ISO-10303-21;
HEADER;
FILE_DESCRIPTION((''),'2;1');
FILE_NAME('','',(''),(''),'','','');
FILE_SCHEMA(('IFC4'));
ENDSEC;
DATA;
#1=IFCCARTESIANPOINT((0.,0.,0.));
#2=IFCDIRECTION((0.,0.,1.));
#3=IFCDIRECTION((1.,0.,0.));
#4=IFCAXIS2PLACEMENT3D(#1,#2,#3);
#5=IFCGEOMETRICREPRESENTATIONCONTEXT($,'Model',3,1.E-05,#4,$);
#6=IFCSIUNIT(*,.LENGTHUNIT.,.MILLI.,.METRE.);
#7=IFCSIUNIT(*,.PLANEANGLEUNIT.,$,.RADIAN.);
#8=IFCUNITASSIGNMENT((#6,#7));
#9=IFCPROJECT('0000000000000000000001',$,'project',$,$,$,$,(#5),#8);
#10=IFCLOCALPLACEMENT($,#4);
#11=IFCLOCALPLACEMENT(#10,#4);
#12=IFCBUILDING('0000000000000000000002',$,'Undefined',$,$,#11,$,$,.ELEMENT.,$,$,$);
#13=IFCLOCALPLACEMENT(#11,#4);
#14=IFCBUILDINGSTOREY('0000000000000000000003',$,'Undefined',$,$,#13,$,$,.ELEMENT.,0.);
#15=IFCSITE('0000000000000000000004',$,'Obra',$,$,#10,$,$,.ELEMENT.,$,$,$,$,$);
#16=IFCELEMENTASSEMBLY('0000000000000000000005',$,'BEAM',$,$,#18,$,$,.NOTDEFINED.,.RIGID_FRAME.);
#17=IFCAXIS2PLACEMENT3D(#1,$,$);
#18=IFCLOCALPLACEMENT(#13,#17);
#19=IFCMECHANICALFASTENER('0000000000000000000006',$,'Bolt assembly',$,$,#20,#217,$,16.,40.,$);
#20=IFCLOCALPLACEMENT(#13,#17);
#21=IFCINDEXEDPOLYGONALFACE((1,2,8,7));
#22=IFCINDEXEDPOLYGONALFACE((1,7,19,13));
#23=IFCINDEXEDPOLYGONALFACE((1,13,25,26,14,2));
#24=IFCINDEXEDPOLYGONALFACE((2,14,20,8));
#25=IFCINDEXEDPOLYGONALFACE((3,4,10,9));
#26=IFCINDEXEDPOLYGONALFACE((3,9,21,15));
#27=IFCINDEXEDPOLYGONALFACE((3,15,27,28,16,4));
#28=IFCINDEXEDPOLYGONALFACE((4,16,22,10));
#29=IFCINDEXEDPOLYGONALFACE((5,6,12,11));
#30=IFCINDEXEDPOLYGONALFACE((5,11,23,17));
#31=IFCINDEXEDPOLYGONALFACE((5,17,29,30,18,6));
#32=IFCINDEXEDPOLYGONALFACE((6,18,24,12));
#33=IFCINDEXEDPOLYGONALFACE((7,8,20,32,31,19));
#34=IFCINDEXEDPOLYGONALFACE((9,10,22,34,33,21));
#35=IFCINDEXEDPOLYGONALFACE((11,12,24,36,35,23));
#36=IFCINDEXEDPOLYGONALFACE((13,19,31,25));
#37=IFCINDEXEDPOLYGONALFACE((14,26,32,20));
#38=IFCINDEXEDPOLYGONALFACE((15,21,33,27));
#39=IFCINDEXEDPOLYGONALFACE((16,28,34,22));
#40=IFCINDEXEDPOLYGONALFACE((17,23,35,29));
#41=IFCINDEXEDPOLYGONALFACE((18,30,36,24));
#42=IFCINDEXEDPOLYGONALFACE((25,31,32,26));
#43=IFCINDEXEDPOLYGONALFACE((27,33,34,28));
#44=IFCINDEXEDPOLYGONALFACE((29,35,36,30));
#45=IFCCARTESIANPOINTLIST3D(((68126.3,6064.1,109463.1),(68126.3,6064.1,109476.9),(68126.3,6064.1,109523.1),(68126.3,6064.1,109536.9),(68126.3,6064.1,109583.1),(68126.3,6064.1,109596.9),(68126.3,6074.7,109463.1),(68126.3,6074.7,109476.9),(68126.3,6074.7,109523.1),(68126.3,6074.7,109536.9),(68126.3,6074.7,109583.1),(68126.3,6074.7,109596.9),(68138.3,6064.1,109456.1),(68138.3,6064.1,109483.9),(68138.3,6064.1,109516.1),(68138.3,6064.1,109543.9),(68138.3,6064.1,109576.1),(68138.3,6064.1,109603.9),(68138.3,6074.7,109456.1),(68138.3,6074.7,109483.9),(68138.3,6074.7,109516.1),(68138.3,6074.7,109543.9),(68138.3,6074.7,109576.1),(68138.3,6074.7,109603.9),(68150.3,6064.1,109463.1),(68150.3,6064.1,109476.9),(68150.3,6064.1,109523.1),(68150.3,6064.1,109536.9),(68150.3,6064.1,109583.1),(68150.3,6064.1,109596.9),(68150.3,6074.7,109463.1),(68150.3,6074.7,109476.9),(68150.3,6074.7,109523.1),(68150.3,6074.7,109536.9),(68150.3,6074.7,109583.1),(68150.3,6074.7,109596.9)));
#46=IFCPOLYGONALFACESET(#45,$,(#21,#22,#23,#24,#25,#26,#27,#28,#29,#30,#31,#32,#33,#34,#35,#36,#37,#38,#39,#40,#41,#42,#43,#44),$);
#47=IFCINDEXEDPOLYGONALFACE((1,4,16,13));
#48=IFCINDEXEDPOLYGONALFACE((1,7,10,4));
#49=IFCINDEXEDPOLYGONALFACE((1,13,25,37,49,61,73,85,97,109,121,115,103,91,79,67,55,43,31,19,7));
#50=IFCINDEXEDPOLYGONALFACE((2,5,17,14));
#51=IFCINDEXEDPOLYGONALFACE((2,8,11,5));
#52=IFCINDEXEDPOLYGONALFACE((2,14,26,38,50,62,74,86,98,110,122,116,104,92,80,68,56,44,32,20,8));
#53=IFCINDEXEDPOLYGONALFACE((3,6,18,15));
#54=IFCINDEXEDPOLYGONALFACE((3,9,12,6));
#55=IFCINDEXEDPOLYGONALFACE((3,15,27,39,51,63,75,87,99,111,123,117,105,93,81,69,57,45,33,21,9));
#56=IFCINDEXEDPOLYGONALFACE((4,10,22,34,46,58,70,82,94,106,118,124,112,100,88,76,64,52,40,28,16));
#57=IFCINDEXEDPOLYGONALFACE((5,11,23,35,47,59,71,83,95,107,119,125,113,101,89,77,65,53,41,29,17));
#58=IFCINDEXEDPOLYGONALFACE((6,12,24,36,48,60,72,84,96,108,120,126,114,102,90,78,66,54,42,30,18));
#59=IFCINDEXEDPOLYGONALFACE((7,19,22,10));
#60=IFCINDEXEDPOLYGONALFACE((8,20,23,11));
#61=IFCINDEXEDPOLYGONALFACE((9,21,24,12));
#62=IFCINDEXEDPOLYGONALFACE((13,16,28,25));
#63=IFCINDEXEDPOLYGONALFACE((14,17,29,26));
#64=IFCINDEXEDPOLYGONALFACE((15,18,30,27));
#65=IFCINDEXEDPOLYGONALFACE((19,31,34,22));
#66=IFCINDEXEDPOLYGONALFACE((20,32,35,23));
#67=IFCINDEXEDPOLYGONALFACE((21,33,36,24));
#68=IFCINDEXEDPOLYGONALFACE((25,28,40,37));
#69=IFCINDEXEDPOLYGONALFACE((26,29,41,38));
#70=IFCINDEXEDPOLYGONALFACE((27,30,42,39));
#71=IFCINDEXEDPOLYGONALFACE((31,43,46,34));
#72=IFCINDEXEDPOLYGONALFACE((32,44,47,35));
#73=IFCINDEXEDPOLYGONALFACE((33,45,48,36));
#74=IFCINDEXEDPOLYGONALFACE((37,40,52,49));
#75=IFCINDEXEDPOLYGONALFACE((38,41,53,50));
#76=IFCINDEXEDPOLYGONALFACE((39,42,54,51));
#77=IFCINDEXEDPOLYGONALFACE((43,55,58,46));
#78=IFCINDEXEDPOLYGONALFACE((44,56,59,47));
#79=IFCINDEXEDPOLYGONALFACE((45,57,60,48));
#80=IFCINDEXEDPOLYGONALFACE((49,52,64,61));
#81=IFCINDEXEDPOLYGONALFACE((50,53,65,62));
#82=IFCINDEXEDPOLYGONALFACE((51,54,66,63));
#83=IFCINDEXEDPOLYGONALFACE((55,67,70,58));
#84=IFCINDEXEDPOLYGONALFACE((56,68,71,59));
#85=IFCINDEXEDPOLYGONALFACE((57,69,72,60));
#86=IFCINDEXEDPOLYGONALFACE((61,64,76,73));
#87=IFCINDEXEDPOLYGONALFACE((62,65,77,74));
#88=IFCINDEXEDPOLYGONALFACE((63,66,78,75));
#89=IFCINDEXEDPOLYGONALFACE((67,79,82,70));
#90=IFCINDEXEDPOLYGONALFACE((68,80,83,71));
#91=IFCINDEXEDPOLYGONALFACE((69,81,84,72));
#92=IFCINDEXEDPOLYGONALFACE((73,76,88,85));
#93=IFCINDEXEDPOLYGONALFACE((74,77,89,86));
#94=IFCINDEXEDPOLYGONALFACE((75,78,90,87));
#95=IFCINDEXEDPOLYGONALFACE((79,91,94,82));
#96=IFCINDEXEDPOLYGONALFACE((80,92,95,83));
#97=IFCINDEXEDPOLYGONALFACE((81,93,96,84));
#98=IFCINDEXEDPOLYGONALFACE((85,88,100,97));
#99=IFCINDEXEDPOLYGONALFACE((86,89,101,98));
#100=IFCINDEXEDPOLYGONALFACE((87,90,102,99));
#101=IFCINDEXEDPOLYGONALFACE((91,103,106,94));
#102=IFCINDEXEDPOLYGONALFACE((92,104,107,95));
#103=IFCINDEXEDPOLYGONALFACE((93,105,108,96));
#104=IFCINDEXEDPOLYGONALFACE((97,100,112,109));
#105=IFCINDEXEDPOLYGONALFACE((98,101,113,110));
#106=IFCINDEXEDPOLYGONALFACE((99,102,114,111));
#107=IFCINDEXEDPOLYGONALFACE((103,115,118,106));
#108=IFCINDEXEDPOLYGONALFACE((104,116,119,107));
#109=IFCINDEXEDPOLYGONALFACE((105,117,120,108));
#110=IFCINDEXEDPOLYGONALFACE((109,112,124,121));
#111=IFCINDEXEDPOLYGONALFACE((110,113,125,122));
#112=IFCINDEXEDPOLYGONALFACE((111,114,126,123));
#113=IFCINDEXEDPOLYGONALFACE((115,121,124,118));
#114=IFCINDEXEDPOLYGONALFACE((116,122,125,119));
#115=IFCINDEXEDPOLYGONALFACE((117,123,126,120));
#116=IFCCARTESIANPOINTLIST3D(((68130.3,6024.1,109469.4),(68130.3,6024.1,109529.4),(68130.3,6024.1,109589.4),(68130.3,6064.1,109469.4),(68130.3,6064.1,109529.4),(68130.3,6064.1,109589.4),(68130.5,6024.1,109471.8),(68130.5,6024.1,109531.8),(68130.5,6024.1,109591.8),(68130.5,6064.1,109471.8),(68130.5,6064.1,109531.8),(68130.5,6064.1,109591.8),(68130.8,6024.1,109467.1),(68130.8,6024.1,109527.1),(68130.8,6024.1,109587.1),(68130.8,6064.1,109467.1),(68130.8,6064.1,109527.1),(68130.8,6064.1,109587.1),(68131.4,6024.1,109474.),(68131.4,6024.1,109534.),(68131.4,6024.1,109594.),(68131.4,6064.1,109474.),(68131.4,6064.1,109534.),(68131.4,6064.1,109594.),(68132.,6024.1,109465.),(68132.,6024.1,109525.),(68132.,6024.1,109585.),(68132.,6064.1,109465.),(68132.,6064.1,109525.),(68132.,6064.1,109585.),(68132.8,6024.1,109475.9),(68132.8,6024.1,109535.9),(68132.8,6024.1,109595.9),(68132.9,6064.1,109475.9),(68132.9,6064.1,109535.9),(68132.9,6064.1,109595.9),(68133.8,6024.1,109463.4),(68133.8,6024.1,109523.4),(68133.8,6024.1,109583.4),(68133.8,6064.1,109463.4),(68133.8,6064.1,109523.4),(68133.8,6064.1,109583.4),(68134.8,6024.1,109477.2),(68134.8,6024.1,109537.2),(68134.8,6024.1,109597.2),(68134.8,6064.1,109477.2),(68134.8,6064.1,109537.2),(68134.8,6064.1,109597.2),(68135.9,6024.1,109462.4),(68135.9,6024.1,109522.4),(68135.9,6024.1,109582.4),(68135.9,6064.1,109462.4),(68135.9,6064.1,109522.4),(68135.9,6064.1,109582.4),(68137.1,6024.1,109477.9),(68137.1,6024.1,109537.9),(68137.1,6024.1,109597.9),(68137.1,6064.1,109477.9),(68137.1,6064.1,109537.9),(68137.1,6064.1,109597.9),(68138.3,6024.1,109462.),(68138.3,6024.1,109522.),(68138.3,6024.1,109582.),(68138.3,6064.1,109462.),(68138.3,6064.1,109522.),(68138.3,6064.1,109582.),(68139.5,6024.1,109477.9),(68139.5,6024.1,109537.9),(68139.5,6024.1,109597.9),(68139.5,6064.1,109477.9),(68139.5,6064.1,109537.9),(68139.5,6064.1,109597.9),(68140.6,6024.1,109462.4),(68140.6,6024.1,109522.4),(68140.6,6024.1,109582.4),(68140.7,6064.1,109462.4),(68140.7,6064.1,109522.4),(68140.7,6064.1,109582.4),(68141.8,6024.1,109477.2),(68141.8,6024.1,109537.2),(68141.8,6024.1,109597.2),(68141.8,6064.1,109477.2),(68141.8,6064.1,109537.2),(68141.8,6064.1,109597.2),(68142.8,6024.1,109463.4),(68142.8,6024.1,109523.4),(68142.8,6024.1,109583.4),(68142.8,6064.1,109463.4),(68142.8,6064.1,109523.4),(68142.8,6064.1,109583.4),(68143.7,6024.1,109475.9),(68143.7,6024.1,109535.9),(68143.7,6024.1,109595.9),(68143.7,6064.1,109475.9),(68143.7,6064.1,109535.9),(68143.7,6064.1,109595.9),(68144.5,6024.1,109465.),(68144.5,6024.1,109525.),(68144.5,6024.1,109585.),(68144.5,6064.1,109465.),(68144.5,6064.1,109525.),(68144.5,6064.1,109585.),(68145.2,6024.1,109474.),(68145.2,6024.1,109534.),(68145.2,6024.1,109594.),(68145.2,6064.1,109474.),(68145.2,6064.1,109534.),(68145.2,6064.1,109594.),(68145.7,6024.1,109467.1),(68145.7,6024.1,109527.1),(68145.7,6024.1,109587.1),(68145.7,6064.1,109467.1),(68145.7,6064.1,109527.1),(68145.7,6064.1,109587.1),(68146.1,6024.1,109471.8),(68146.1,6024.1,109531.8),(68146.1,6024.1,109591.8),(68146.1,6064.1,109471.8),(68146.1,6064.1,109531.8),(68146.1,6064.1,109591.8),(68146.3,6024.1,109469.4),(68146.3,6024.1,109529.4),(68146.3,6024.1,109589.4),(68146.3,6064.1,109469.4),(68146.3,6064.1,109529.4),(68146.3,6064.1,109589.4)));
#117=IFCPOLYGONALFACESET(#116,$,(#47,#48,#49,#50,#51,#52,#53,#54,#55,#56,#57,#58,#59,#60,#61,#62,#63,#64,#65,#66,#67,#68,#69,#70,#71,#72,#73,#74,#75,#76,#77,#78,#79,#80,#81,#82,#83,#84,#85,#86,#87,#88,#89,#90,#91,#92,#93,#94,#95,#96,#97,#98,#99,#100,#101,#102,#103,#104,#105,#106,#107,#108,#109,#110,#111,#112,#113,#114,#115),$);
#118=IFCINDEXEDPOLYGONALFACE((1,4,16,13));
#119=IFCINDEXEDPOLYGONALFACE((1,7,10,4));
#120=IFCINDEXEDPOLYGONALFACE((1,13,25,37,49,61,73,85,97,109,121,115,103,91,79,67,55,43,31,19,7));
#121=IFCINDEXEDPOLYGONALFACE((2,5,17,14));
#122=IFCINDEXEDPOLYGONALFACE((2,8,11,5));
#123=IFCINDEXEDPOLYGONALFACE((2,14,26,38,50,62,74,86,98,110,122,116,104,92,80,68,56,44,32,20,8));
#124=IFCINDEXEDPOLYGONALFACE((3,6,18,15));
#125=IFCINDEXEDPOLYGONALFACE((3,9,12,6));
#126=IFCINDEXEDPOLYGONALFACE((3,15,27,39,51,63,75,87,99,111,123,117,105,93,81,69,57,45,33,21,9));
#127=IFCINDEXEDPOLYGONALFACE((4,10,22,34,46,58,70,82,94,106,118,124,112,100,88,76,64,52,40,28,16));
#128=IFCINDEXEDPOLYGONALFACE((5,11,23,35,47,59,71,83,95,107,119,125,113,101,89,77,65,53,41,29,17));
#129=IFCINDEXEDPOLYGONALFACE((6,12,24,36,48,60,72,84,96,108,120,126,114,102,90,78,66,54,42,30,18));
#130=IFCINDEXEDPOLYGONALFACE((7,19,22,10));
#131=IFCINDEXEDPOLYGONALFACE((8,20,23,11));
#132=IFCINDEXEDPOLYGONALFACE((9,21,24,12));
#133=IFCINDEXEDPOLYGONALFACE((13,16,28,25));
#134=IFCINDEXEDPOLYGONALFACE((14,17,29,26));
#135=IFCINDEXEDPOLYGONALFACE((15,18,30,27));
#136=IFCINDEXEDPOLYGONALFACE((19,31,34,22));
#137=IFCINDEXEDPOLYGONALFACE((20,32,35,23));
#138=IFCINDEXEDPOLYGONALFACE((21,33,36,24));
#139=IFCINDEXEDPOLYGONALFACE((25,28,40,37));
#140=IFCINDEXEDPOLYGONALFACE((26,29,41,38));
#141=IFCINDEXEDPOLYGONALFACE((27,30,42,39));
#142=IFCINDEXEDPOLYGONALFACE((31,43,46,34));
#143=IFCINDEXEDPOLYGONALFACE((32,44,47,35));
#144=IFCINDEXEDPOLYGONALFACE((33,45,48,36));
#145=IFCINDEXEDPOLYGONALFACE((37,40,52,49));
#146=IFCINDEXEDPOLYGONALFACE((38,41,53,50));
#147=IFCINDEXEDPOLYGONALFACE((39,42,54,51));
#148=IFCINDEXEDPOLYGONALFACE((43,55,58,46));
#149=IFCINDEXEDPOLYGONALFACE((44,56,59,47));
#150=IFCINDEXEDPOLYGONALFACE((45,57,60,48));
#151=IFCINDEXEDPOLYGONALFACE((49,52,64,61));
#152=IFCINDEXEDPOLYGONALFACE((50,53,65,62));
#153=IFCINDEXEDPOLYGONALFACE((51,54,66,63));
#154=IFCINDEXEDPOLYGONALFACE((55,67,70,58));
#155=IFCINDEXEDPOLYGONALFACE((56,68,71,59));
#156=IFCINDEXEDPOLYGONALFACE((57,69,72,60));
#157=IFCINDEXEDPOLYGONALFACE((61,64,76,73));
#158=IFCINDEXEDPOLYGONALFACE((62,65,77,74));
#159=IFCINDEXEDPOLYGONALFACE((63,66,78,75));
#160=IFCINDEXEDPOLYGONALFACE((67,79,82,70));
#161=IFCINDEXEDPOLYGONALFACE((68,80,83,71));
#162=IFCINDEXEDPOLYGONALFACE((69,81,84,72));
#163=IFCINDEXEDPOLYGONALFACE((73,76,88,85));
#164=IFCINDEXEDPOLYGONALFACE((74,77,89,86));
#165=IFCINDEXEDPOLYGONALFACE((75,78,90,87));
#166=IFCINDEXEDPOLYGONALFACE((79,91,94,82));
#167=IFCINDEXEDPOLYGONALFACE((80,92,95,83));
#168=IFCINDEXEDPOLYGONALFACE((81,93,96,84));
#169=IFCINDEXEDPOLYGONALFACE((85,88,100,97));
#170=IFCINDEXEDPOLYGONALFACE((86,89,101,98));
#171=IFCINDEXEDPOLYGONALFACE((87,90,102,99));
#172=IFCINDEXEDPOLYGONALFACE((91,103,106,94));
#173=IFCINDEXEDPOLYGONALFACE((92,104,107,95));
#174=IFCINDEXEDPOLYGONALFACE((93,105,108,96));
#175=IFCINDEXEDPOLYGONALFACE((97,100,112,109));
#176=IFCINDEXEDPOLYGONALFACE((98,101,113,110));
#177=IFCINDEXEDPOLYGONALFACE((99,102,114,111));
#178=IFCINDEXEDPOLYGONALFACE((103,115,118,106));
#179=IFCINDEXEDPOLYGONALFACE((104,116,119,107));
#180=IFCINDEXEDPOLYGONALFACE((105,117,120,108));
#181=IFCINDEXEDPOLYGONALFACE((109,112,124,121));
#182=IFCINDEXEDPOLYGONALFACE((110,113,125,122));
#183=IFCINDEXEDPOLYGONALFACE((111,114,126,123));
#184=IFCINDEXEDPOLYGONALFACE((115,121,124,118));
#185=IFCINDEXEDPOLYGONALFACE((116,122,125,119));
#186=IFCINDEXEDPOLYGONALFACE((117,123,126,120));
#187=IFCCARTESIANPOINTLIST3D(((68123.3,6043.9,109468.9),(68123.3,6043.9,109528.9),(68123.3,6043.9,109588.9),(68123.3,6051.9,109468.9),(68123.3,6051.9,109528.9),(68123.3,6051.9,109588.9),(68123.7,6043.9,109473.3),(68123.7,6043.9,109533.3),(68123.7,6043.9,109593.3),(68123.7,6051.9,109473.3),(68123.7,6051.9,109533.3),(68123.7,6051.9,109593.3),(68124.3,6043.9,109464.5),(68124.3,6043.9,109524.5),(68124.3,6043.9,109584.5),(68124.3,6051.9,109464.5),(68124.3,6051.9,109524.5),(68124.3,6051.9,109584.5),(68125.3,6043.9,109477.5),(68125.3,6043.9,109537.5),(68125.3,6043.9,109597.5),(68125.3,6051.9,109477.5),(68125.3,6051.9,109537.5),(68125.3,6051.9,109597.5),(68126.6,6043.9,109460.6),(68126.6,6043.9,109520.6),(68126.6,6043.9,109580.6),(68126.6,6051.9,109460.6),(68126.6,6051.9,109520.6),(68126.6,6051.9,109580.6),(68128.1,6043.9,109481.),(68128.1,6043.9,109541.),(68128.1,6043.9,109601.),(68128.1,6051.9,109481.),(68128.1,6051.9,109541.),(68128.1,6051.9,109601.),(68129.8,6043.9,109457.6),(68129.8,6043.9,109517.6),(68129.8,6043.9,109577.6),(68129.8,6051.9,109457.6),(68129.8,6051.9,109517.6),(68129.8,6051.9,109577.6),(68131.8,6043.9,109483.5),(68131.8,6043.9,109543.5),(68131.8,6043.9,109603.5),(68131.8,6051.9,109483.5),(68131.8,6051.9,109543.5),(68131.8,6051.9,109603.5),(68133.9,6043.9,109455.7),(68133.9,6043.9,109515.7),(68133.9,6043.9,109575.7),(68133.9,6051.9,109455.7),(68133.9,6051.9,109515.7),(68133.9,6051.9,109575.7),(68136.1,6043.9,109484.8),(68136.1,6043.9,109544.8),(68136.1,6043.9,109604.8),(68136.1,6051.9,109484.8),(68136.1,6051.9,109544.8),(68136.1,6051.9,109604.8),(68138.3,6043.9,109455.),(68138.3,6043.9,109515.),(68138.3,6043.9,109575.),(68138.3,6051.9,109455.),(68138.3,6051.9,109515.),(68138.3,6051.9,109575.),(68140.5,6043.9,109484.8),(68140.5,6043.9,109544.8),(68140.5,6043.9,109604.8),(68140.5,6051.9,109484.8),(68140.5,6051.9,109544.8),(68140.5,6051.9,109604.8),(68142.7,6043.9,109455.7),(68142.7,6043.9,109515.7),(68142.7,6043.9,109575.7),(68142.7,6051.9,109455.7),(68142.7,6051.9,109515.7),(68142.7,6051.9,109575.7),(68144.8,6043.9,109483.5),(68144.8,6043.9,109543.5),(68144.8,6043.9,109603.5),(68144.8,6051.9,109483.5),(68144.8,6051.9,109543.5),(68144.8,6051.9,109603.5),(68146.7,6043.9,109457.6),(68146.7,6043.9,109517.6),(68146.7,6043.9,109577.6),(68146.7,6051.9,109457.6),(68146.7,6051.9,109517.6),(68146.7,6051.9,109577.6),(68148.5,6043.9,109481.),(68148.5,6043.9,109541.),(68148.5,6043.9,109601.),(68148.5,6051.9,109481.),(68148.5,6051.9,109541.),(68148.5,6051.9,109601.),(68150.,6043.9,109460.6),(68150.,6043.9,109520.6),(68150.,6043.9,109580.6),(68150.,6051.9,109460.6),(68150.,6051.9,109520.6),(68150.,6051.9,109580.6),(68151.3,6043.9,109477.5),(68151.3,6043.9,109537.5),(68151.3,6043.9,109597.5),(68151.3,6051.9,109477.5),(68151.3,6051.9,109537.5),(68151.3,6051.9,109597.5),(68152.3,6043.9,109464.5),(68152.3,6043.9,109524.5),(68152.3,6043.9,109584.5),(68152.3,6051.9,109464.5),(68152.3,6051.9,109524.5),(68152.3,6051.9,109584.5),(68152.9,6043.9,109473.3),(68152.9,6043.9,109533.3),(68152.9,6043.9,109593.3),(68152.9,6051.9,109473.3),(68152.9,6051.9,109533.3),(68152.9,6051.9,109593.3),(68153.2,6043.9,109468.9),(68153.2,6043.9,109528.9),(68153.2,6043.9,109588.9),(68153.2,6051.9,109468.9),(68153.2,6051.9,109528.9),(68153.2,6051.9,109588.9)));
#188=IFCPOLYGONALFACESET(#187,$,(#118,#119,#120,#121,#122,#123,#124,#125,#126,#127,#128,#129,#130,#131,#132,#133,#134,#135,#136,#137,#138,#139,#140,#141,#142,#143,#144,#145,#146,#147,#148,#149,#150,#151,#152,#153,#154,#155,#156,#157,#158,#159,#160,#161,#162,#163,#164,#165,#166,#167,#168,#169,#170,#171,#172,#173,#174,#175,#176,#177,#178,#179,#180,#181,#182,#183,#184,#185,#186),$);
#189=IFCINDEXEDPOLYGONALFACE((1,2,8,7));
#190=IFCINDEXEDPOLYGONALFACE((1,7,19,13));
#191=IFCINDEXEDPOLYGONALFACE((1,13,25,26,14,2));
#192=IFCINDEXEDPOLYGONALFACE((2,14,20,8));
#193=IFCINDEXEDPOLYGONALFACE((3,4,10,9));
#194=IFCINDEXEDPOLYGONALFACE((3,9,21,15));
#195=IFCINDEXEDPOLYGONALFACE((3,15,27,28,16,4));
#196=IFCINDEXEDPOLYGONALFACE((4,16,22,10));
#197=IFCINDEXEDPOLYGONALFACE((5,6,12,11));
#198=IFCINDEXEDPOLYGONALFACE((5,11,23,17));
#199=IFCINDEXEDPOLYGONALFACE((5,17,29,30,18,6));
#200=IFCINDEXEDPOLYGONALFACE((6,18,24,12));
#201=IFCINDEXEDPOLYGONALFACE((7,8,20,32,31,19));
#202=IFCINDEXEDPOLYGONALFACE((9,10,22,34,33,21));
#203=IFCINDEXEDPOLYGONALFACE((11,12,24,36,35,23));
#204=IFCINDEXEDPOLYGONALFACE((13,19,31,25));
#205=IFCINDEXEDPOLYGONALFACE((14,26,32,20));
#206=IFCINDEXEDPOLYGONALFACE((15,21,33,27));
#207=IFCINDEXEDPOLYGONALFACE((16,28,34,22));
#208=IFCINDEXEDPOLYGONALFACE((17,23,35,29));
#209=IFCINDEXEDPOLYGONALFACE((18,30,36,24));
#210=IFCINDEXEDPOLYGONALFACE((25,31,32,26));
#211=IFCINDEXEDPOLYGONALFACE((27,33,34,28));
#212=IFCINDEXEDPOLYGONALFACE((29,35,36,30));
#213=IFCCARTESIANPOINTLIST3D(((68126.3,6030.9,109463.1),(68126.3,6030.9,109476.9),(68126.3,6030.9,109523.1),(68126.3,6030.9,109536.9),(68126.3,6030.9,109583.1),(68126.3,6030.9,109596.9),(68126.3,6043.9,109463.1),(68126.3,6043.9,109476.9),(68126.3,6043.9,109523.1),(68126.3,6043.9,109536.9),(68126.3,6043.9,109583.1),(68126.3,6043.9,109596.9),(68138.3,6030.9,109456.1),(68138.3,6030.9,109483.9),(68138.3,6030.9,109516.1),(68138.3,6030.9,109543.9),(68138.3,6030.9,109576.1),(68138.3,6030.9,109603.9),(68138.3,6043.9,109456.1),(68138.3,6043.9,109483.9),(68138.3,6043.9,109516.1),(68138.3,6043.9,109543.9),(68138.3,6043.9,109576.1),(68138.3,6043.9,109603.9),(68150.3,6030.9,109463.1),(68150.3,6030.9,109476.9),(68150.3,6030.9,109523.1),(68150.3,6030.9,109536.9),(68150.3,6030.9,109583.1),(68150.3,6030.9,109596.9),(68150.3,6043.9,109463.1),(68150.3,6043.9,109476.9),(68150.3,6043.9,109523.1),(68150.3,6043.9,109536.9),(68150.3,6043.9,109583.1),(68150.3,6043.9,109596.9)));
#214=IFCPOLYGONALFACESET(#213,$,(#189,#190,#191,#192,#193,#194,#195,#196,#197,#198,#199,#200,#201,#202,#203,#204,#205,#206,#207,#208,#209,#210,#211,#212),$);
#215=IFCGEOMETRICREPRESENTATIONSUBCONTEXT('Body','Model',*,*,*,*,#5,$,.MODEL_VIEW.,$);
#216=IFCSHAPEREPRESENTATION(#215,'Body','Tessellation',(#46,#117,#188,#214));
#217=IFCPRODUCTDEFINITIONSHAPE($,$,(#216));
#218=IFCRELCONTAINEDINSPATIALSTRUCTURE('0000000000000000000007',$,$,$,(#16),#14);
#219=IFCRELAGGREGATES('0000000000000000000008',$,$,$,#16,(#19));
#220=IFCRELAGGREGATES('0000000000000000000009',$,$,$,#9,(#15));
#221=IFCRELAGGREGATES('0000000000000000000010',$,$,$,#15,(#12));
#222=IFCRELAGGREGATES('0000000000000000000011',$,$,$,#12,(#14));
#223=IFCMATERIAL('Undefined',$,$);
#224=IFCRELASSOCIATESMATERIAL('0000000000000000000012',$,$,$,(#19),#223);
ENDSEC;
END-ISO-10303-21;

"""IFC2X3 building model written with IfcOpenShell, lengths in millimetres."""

from ifc_helpers import new_model, si_unit, frame, origin_with_axes, origin_2d_with_axis, place, context, subcontext, project, spatial, polyline, circle, outline, extrude, source, transform, mapped, material, element, aggregate, save


model = new_model("IFC2X3")

# Units and contexts
model_context = context("Model", 3, precision=1e-05, world=origin_with_axes())
body_context = subcontext(model_context, "Body", "Model", "MODEL_VIEW")
ifc_project = project(units=[si_unit("LENGTHUNIT", "METRE", prefix="MILLI"), si_unit("PLANEANGLEUNIT", "RADIAN")], contexts=[model_context])

# Site, building, storey
site_placement = place(None, origin_with_axes())
site = spatial("IfcSite", under=ifc_project, at=site_placement, Name="Obra", CompositionType="ELEMENT")
building_placement = place(site_placement, origin_with_axes())
building = spatial("IfcBuilding", under=site, at=building_placement, Name="Undefined", CompositionType="ELEMENT")
storey_placement = place(building_placement, origin_with_axes())
storey = spatial("IfcBuildingStorey", under=building, at=storey_placement, Name="Undefined", CompositionType="ELEMENT", Elevation=0.0)

# Shared definitions
ifc_material_1 = material(Name="Undefined")

# Shared definitions
shared_shape_1 = source(origin_with_axes(), body_context, "Body", "SweptSolid", [
    extrude(outline(polyline([(13.9, 0.0), (6.9, 12.0), (-6.9, 12.0), (-13.9, 0.0), (-6.9, -12.0), (6.9, -12.0), (13.9, 0.0)])), frame((0.0, -19.7, 0.0), z_axis=(0.0, 1.0, 0.0), x_axis=(1.0, 0.0, 0.0)), (0.0, 0.0, 1.0), 10.6),
    extrude(circle(Radius=8.0, at=origin_2d_with_axis()), frame((0.0, -9.1, 0.0), z_axis=(0.0, 1.0, 0.0), x_axis=(1.0, 0.0, 0.0)), (0.0, 0.0, 1.0), 40.0),
    extrude(circle(Radius=15.0, at=origin_2d_with_axis()), frame((0.0, 3.1, 0.0), z_axis=(0.0, 1.0, 0.0), x_axis=(1.0, 0.0, 0.0)), (0.0, 0.0, 1.0), 8.0),
    extrude(outline(polyline([(13.9, 0.0), (6.9, 12.0), (-6.9, 12.0), (-13.9, 0.0), (-6.9, -12.0), (6.9, -12.0), (13.9, 0.0)])), frame((0.0, 11.1, 0.0), z_axis=(0.0, 1.0, 0.0), x_axis=(1.0, 0.0, 0.0)), (0.0, 0.0, 1.0), 13.0),
])

# Element assembly, mechanical fastener
assembly_1_placement = place(storey_placement, origin_with_axes())
assembly_1 = element("IfcElementAssembly", 1, at=assembly_1_placement, inside=storey, Name="BEAM", AssemblyPlace="NOTDEFINED", PredefinedType="RIGID_FRAME")
mechanical_fastener_1_placement = place(assembly_1_placement, frame((68188.3, 6055.0, 109650.0), z_axis=(-1.0, 0.000126, 0.0), x_axis=(0.0, 0.0, -1.0)))
mechanical_fastener_1 = element("IfcMechanicalFastener", 2, at=mechanical_fastener_1_placement, material=ifc_material_1, Name="Bolt assembly", NominalDiameter=16.0, NominalLength=40.0, context=body_context, shape_type="MappedRepresentation", body=[
    mapped(shared_shape_1, transform((60.0, 0.0, 50.0))),
    mapped(shared_shape_1, transform((120.0, 0.0, 50.0))),
    mapped(shared_shape_1, transform((180.0, 0.0, 50.0))),
])
aggregate(assembly_1, [mechanical_fastener_1])

save(model, "model.ifc")
